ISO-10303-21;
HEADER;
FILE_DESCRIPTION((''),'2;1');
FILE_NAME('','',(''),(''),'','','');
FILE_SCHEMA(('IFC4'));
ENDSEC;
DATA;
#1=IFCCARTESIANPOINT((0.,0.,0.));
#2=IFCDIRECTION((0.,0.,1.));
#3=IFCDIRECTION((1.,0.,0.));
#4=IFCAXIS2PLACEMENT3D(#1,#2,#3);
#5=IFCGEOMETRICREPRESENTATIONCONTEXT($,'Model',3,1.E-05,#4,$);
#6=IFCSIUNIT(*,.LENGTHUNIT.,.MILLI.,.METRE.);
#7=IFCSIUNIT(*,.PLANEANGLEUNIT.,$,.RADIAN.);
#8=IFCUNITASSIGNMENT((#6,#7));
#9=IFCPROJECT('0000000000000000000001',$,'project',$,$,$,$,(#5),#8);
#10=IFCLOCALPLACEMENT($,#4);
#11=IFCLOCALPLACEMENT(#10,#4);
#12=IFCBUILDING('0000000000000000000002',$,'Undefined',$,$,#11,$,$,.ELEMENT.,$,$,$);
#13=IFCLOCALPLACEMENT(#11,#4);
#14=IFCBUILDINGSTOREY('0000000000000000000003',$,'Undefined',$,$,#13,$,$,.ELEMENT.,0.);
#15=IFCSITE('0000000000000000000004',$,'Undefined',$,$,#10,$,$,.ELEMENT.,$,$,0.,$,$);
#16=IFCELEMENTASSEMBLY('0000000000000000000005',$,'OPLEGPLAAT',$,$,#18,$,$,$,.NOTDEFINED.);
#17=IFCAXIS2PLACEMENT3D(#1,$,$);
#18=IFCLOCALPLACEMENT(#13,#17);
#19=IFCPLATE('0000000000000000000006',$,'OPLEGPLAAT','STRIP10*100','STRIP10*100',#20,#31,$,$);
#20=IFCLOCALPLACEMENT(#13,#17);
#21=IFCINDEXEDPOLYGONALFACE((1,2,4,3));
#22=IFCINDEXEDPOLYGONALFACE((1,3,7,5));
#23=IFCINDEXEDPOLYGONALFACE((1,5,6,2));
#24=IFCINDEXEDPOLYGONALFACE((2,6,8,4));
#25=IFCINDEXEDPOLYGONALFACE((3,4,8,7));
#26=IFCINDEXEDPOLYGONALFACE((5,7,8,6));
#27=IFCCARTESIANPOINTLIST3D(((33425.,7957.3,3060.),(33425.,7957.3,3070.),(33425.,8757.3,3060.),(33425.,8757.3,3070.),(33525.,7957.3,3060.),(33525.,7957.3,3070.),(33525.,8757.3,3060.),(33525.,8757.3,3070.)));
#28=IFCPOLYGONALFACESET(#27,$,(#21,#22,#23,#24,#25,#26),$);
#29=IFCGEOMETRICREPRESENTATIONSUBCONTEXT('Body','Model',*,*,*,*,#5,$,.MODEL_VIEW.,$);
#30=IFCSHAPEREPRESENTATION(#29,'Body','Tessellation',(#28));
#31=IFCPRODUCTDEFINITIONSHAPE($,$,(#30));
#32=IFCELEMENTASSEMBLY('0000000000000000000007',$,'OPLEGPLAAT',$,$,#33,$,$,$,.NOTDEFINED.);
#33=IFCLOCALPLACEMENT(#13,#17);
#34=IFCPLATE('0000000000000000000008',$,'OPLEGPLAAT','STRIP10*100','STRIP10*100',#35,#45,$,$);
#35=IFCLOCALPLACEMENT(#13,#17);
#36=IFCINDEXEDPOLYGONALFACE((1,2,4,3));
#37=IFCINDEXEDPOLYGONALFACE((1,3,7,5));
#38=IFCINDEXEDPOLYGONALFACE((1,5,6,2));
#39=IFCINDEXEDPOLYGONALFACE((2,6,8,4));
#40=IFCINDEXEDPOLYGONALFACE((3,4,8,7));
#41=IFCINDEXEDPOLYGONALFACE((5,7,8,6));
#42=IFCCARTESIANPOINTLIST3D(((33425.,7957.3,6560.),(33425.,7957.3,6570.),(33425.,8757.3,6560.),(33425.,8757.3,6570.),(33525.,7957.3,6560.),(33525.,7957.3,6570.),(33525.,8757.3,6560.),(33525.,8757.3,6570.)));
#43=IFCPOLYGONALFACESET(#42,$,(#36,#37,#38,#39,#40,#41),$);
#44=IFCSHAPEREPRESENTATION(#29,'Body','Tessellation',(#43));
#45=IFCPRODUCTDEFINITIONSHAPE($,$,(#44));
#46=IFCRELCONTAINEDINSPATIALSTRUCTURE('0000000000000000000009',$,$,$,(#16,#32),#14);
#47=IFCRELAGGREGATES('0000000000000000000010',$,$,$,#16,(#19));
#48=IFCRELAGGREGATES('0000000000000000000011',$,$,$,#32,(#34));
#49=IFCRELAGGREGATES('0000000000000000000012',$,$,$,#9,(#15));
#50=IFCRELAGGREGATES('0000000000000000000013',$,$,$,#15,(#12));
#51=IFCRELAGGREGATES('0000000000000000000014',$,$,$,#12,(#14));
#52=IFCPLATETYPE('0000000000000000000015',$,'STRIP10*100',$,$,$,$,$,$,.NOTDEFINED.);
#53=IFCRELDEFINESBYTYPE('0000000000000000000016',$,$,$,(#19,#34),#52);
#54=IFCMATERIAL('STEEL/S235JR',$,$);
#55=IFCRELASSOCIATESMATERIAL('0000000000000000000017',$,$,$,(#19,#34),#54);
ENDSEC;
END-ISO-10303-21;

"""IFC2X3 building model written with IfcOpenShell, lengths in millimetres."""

from ifc_helpers import new_model, si_unit, frame, origin_with_axes, origin_2d_with_axis, place, context, subcontext, project, spatial, rectangle, extrude, material, type_object, element, aggregate, save


model = new_model("IFC2X3")

# Units and contexts
model_context = context("Model", 3, precision=1e-05, world=origin_with_axes())
body_context = subcontext(model_context, "Body", "Model", "MODEL_VIEW")
ifc_project = project(units=[si_unit("LENGTHUNIT", "METRE", prefix="MILLI"), si_unit("PLANEANGLEUNIT", "RADIAN")], contexts=[model_context])

# Site, building, storey
site_placement = place(None, origin_with_axes())
site = spatial("IfcSite", under=ifc_project, at=site_placement, Name="Undefined", CompositionType="ELEMENT", RefElevation=0.0)
building_placement = place(site_placement, origin_with_axes())
building = spatial("IfcBuilding", under=site, at=building_placement, Name="Undefined", CompositionType="ELEMENT")
storey_placement = place(building_placement, origin_with_axes())
storey = spatial("IfcBuildingStorey", under=building, at=storey_placement, Name="Undefined", CompositionType="ELEMENT", Elevation=0.0)

# Shared definitions
ifc_material = material(Name="STEEL/S235JR")

# Element assemblies, plates
plate_type = type_object("IfcPlateType", Name="STRIP10*100", PredefinedType="NOTDEFINED")
assembly_1_placement = place(storey_placement, origin_with_axes())
assembly_1 = element("IfcElementAssembly", 1, at=assembly_1_placement, inside=storey, Name="OPLEGPLAAT", PredefinedType="NOTDEFINED")
plate_1_placement = place(assembly_1_placement, frame((33475.0, 7957.3, 3065.0), z_axis=(-1.0, 0.0, 0.0), x_axis=(0.0, 1.0, 0.0)))
plate_1 = element("IfcPlate", 2, at=plate_1_placement, type_object=plate_type, material=ifc_material, Name="OPLEGPLAAT", Description="STRIP10*100", ObjectType="STRIP10*100", context=body_context, shape_type="SweptSolid", body=[
    extrude(rectangle(XDim=10.0, YDim=100.0, at=origin_2d_with_axis()), frame((800.0, 0.0, 0.0), z_axis=(-1.0, 0.0, 0.0), x_axis=(0.0, -1.0, 0.0)), (0.0, 0.0, 1.0), 800.0),
])
aggregate(assembly_1, [plate_1])
assembly_2_placement = place(storey_placement, origin_with_axes())
assembly_2 = element("IfcElementAssembly", 3, at=assembly_2_placement, inside=storey, Name="OPLEGPLAAT", PredefinedType="NOTDEFINED")
plate_2_placement = place(assembly_2_placement, frame((33475.0, 7957.3, 6565.0), z_axis=(-1.0, 0.0, 0.0), x_axis=(0.0, 1.0, 0.0)))
plate_2 = element("IfcPlate", 4, at=plate_2_placement, type_object=plate_type, material=ifc_material, Name="OPLEGPLAAT", Description="STRIP10*100", ObjectType="STRIP10*100", context=body_context, shape_type="SweptSolid", body=[
    extrude(rectangle(XDim=10.0, YDim=100.0, at=origin_2d_with_axis()), frame((800.0, 0.0, 0.0), z_axis=(-1.0, 0.0, 0.0), x_axis=(0.0, -1.0, 0.0)), (0.0, 0.0, 1.0), 800.0),
])
aggregate(assembly_2, [plate_2])

save(model, "model.ifc")
